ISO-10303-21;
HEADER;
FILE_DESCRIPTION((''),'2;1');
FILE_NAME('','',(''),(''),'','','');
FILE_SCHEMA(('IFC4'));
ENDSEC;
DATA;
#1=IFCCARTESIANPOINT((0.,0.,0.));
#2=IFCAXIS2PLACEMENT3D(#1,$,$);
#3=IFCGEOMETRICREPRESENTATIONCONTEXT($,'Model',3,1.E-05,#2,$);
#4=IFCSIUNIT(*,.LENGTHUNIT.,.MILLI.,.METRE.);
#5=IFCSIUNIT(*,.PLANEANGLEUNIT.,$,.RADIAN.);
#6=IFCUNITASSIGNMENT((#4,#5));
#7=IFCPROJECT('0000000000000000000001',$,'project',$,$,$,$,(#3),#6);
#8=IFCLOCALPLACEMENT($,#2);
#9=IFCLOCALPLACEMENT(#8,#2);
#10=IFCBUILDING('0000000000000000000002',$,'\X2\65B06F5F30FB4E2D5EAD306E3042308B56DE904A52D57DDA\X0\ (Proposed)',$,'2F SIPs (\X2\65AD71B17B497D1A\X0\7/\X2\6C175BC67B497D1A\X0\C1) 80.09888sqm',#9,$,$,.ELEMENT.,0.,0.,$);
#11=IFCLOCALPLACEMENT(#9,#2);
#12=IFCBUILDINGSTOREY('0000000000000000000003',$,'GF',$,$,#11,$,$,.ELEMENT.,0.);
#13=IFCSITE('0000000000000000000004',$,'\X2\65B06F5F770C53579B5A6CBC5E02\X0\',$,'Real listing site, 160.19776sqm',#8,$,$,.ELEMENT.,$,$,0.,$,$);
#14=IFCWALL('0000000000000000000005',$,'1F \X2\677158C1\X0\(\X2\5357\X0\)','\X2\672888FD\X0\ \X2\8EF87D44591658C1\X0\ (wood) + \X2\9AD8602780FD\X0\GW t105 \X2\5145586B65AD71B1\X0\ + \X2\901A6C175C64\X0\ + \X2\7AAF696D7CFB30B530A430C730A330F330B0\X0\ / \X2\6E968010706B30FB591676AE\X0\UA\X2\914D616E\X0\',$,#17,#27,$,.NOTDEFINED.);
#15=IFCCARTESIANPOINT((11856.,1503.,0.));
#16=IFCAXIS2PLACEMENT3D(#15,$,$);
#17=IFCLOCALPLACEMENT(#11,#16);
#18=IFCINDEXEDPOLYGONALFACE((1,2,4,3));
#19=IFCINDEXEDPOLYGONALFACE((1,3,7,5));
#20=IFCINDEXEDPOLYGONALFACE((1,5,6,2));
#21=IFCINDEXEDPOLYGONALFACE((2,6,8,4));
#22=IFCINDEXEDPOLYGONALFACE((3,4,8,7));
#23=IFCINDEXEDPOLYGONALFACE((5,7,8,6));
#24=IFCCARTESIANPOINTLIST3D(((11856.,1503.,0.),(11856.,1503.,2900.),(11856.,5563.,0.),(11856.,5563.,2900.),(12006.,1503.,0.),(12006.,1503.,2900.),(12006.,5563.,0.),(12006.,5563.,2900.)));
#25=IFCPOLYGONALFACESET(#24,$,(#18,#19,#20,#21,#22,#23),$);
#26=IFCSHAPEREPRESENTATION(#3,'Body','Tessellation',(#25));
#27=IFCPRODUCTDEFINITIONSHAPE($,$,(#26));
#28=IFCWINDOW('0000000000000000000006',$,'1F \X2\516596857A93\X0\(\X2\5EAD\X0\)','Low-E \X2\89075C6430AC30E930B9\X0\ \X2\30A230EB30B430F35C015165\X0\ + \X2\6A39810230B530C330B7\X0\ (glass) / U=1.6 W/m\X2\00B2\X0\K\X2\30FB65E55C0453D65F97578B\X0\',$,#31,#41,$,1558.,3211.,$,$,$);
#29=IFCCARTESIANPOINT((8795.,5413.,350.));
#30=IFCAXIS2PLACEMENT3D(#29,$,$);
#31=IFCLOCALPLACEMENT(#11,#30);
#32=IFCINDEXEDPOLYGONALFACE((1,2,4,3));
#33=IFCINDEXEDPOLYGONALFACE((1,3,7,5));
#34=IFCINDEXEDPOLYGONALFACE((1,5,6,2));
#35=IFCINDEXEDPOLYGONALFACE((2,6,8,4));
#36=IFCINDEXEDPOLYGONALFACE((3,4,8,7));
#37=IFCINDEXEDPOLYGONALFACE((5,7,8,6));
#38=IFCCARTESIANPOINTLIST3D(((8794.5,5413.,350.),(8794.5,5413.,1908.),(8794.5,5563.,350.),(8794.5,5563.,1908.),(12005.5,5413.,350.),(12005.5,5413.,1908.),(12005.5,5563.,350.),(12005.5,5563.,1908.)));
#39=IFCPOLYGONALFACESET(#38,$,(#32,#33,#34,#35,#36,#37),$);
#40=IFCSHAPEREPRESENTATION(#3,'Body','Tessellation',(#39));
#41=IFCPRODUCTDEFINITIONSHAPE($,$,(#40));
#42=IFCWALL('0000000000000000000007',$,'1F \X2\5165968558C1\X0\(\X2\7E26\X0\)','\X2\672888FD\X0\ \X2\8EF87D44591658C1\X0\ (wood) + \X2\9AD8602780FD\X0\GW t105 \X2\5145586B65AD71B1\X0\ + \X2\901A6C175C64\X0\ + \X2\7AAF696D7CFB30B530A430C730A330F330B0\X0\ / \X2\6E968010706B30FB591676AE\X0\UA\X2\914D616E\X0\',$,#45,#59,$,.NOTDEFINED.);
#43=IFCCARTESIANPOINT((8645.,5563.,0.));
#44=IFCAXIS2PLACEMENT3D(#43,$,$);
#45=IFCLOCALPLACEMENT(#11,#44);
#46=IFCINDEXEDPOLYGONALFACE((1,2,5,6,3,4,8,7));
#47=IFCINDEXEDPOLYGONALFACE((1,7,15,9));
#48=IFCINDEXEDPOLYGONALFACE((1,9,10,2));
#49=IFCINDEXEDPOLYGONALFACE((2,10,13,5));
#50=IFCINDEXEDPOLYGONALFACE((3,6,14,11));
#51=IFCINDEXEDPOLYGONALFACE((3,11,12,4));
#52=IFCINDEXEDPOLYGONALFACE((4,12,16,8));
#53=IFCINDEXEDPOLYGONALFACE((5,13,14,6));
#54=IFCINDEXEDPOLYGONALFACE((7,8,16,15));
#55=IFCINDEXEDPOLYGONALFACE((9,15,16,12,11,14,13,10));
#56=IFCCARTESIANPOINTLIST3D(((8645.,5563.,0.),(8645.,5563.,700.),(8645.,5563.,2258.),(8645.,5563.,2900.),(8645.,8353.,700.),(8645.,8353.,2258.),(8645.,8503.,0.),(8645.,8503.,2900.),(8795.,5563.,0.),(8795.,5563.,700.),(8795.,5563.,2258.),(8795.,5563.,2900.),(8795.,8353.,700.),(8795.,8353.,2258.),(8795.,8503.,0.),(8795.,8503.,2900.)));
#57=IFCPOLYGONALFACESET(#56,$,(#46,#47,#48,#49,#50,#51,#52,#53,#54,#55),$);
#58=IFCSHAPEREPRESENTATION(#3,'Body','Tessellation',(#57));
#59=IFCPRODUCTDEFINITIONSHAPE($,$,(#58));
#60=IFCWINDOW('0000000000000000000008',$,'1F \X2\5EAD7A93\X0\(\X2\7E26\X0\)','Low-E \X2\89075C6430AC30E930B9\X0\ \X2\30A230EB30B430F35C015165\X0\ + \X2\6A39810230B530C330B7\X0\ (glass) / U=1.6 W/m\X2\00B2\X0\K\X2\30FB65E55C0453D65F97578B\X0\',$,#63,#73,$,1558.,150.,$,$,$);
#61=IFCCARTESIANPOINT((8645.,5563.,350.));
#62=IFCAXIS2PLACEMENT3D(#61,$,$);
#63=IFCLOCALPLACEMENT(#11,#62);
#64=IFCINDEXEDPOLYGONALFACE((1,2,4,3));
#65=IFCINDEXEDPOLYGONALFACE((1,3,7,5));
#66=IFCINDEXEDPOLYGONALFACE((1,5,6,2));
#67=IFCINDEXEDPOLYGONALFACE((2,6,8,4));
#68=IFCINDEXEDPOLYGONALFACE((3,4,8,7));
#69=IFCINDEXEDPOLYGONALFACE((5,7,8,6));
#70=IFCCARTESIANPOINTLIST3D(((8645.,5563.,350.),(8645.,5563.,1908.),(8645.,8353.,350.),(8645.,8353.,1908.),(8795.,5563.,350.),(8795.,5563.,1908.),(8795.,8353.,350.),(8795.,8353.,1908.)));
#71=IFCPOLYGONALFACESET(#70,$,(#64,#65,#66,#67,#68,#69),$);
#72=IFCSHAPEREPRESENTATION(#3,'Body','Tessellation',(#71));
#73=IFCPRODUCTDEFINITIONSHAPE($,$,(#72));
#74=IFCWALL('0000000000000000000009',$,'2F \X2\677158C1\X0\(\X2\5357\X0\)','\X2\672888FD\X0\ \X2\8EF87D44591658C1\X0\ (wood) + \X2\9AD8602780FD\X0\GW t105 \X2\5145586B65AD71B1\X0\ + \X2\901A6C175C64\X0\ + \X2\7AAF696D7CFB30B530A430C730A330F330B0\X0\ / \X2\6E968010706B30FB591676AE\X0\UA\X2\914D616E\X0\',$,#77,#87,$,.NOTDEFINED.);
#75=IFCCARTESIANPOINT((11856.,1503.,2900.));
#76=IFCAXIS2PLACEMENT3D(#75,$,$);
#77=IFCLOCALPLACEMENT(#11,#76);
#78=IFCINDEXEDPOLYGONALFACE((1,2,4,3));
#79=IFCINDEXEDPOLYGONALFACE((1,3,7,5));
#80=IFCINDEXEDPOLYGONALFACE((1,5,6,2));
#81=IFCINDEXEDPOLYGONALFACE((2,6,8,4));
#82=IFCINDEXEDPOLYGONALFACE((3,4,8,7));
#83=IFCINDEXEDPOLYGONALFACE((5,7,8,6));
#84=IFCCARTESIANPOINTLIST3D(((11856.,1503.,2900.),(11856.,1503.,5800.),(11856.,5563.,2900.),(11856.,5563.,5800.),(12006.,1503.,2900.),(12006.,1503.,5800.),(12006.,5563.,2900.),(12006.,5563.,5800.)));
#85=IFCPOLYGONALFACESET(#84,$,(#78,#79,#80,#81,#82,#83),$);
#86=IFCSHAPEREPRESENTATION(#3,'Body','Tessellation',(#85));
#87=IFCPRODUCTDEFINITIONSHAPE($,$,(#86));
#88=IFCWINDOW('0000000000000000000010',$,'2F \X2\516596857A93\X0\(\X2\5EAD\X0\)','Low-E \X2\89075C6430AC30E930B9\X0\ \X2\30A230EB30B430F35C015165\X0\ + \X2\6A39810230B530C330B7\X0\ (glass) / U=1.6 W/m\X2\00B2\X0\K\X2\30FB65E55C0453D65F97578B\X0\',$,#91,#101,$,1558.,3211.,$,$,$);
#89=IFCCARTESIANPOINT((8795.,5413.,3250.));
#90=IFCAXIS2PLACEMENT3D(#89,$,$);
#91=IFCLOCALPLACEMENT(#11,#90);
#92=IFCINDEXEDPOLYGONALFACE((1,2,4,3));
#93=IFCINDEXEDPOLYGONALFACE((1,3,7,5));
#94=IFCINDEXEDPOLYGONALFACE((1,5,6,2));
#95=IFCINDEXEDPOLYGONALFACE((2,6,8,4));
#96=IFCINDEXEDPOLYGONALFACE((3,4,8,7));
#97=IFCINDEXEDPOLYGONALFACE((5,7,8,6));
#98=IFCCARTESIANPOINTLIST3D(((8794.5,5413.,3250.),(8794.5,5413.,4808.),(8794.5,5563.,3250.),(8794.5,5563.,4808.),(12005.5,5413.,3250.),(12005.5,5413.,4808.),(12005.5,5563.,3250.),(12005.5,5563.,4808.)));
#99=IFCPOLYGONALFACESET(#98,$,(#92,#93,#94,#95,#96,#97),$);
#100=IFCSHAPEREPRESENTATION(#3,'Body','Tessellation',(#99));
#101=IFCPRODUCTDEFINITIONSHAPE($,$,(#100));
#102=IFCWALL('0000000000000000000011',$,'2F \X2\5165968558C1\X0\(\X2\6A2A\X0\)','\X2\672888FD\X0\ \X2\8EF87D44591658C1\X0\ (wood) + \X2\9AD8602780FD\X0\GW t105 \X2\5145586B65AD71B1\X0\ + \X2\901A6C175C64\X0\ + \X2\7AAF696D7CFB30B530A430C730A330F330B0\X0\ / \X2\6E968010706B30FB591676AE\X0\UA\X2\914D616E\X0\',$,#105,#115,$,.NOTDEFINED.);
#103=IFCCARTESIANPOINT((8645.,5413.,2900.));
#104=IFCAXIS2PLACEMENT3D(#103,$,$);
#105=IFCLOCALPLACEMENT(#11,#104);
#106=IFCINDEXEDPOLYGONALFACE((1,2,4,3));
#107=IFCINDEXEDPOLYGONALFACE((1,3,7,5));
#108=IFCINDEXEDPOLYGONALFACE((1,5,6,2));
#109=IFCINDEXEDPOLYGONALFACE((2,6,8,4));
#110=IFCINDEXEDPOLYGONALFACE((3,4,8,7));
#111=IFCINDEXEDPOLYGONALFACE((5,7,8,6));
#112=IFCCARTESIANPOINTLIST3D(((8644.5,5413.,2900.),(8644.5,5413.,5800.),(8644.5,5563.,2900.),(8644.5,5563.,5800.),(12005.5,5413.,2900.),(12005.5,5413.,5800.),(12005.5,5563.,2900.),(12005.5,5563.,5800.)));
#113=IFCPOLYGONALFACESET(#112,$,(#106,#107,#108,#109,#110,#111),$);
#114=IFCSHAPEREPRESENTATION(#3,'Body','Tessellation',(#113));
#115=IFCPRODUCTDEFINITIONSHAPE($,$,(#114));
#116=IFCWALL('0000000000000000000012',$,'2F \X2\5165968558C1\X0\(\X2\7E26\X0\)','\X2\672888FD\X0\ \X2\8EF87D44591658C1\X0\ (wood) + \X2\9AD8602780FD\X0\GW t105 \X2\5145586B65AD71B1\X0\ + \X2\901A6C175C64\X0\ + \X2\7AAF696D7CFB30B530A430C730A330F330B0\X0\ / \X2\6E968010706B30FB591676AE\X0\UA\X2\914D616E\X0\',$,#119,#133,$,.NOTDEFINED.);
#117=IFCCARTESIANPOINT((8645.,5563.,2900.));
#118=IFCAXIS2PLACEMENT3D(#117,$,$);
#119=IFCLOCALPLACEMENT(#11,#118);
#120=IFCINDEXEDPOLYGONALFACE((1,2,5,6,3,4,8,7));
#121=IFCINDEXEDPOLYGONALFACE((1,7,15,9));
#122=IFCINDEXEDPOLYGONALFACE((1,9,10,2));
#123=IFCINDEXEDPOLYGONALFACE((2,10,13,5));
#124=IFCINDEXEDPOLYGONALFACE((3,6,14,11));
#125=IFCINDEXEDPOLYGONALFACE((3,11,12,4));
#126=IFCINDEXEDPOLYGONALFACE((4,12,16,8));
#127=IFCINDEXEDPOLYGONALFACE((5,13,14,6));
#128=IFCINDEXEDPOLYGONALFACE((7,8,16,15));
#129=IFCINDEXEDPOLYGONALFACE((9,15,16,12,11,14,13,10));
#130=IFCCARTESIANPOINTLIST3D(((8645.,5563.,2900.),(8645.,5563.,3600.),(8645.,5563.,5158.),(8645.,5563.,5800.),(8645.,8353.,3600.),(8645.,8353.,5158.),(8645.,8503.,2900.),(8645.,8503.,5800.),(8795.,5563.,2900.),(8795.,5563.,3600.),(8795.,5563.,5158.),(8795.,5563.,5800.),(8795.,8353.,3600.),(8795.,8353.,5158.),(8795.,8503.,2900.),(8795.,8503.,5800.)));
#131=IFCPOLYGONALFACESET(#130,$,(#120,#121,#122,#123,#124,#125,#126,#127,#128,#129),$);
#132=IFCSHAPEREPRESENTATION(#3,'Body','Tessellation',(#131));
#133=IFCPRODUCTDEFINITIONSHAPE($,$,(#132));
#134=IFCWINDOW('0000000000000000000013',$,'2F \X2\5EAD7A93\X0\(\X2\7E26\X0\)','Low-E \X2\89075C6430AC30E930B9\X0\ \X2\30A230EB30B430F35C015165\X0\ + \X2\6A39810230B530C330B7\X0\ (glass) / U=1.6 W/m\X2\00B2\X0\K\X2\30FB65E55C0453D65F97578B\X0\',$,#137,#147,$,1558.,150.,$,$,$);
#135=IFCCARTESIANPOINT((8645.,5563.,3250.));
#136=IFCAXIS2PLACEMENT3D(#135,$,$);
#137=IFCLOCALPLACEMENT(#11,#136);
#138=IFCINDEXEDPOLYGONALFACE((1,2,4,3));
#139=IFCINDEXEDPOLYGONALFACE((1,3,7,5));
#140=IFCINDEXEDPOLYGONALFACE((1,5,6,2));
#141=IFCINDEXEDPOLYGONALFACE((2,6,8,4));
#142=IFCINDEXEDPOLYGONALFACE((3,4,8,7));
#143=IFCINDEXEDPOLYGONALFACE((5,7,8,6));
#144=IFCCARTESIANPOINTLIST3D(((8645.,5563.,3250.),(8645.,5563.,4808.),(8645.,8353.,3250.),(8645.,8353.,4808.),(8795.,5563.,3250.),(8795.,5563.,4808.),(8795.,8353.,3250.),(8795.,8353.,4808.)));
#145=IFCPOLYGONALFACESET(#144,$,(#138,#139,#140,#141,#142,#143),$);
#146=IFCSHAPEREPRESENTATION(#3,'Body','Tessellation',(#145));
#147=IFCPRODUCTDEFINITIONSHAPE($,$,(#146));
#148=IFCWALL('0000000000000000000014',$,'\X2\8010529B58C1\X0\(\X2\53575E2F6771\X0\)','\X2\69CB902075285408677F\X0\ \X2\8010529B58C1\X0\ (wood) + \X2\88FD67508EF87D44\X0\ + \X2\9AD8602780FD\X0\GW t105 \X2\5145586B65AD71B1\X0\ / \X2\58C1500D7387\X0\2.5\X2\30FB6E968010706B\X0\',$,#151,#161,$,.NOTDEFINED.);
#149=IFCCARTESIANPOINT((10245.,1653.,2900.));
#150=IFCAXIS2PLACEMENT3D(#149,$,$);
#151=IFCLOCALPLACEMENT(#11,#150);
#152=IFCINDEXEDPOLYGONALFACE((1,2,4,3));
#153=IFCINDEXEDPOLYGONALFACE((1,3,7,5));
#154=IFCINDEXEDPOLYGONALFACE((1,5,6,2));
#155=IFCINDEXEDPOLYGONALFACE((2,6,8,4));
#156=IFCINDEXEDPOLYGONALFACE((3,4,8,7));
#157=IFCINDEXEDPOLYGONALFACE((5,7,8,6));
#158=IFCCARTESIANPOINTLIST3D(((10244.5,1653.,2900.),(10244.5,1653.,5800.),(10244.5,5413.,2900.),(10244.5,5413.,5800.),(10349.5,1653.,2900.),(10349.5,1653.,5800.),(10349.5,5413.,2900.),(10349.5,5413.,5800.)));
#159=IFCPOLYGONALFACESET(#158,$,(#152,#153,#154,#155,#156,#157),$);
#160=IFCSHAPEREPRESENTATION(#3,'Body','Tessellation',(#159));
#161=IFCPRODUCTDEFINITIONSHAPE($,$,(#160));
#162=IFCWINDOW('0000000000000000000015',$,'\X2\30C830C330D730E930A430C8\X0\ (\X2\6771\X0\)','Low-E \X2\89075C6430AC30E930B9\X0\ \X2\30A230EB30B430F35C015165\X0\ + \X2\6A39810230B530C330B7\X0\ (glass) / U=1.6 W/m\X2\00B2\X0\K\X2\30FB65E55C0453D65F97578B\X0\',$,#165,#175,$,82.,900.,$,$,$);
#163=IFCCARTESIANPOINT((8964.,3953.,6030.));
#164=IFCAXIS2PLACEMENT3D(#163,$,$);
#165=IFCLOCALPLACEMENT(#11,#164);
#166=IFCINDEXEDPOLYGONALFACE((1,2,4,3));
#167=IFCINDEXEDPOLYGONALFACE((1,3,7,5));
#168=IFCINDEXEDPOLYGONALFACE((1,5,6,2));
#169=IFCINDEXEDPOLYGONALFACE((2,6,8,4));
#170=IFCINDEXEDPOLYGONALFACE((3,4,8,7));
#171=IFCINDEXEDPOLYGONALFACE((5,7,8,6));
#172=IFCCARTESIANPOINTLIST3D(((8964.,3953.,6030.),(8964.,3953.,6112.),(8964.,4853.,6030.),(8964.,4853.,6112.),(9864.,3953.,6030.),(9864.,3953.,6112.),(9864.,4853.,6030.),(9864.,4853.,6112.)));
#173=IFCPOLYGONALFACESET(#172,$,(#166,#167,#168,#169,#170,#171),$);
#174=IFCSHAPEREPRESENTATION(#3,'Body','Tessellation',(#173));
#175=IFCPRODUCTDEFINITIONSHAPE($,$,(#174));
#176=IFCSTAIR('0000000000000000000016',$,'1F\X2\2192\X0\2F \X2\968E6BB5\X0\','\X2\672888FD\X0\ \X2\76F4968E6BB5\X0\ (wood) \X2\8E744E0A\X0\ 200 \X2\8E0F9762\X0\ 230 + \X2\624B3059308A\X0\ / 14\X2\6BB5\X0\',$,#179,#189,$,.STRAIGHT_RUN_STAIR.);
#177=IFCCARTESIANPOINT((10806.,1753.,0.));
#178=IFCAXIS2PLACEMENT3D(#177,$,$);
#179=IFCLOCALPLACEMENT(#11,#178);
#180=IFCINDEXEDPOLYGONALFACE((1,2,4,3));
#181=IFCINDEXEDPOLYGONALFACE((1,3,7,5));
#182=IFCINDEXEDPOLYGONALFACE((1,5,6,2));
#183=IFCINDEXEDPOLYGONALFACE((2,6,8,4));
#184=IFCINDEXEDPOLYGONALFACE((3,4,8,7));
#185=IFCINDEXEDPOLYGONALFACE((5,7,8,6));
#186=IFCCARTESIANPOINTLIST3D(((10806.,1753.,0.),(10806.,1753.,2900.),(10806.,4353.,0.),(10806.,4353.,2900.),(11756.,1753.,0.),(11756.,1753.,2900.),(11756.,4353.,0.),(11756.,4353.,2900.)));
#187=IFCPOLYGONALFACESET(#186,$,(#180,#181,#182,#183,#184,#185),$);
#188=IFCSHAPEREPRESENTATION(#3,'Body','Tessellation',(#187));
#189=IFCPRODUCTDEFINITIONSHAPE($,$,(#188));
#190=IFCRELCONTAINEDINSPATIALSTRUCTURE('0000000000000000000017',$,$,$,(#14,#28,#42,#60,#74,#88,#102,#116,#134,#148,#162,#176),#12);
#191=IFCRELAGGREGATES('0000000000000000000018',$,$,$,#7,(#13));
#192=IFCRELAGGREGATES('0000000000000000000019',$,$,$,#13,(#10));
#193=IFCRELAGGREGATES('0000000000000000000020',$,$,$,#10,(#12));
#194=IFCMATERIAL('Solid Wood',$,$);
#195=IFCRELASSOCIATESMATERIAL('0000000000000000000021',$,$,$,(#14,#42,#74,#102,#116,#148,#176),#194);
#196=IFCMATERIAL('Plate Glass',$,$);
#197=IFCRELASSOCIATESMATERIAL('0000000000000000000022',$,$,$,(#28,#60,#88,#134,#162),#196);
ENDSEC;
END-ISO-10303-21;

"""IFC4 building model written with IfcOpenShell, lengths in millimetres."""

from ifc_helpers import new_model, si_unit, frame, frame_2d, origin, place, context, project, spatial, rectangle, extrude, material, element, fill, save


model = new_model("IFC4")

# Units and contexts
model_context = context("Model", 3, precision=1e-05, world=origin())
ifc_project = project(units=[si_unit("LENGTHUNIT", "METRE", prefix="MILLI"), si_unit("PLANEANGLEUNIT", "RADIAN")], contexts=[model_context])

# Site, building, storey
site_placement = place(None, origin())
site = spatial("IfcSite", under=ifc_project, at=site_placement, Name="新潟県南魚沼市", ObjectType="Real listing site, 160.19776sqm", CompositionType="ELEMENT", RefElevation=0.0)
building_placement = place(site_placement, origin())
building = spatial("IfcBuilding", under=site, at=building_placement, Name="新潟・中庭のある回遊動線 (Proposed)", ObjectType="2F SIPs (断熱等級7/気密等級C1) 80.09888sqm", CompositionType="ELEMENT", ElevationOfRefHeight=0.0, ElevationOfTerrain=0.0)
storey_placement = place(building_placement, origin())
storey = spatial("IfcBuildingStorey", under=building, at=storey_placement, Name="GF", CompositionType="ELEMENT", Elevation=0.0)

# Shared definitions
ifc_material_1 = material(Name="Solid Wood")

# Wall, opening, window
wall_1_placement = place(storey_placement, frame((11856.0, 1503.0, 0.0)))
wall_1 = element("IfcWall", 1, at=wall_1_placement, inside=storey, material=ifc_material_1, Name="1F 東壁(南)", Description="木製 軸組外壁 (wood) + 高性能GW t105 充填断熱 + 通気層 + 窯業系サイディング / 準耐火・外皮UA配慮", PredefinedType="NOTDEFINED", context=model_context, shape_type="SweptSolid", body=[
    extrude(rectangle(XDim=150.0, YDim=4060.0, at=frame_2d((75.0, 2030.0))), frame((11856.0, 1503.0, 0.0)), (0.0, 0.0, 1.0), 2900.0),
])
opening_1_placement = place(storey_placement, frame((8795.0, 5413.0, 350.0)))
opening_1 = element("IfcOpeningElement", 2, at=opening_1_placement, cuts=wall_1, PredefinedType="NOTDEFINED", context=model_context, shape_type="SweptSolid", body=[
    extrude(rectangle(XDim=3211.0, YDim=150.0, at=frame_2d((1605.0, 75.0))), frame((8795.0, 5413.0, 350.0)), (0.0, 0.0, 1.0), 1558.0),
])
ifc_material_2 = material(Name="Plate Glass")
window_1_placement = place(storey_placement, frame((8795.0, 5413.0, 350.0)))
window_1 = element("IfcWindow", 3, at=window_1_placement, inside=storey, material=ifc_material_2, Name="1F 入隅窓(庭)", Description="Low-E 複層ガラス アルゴン封入 + 樹脂サッシ (glass) / U=1.6 W/m²K・日射取得型", OverallHeight=1558.0, OverallWidth=3211.0, context=model_context, shape_type="SweptSolid", body=[
    extrude(rectangle(XDim=3211.0, YDim=150.0, at=frame_2d((1605.0, 75.0))), frame((8795.0, 5413.0, 350.0)), (0.0, 0.0, 1.0), 1558.0),
])
fill(opening_1, window_1)

# Wall, opening, window
wall_2_placement = place(storey_placement, frame((8645.0, 5563.0, 0.0)))
wall_2 = element("IfcWall", 4, at=wall_2_placement, inside=storey, material=ifc_material_1, Name="1F 入隅壁(縦)", Description="木製 軸組外壁 (wood) + 高性能GW t105 充填断熱 + 通気層 + 窯業系サイディング / 準耐火・外皮UA配慮", PredefinedType="NOTDEFINED", context=model_context, shape_type="SweptSolid", body=[
    extrude(rectangle(XDim=150.0, YDim=2940.0, at=frame_2d((75.0, 1470.0))), frame((8645.0, 5563.0, 0.0)), (0.0, 0.0, 1.0), 2900.0),
])
opening_2_placement = place(storey_placement, frame((8645.0, 5563.0, 350.0)))
opening_2 = element("IfcOpeningElement", 5, at=opening_2_placement, cuts=wall_2, PredefinedType="NOTDEFINED", context=model_context, shape_type="SweptSolid", body=[
    extrude(rectangle(XDim=150.0, YDim=2790.0, at=frame_2d((75.0, 1395.0))), frame((8645.0, 5563.0, 350.0)), (0.0, 0.0, 1.0), 1558.0),
])
window_2_placement = place(storey_placement, frame((8645.0, 5563.0, 350.0)))
window_2 = element("IfcWindow", 6, at=window_2_placement, inside=storey, material=ifc_material_2, Name="1F 庭窓(縦)", Description="Low-E 複層ガラス アルゴン封入 + 樹脂サッシ (glass) / U=1.6 W/m²K・日射取得型", OverallHeight=1558.0, OverallWidth=150.0, context=model_context, shape_type="SweptSolid", body=[
    extrude(rectangle(XDim=150.0, YDim=2790.0, at=frame_2d((75.0, 1395.0))), frame((8645.0, 5563.0, 350.0)), (0.0, 0.0, 1.0), 1558.0),
])
fill(opening_2, window_2)

# Wall, opening, window
wall_3_placement = place(storey_placement, frame((11856.0, 1503.0, 2900.0)))
wall_3 = element("IfcWall", 7, at=wall_3_placement, inside=storey, material=ifc_material_1, Name="2F 東壁(南)", Description="木製 軸組外壁 (wood) + 高性能GW t105 充填断熱 + 通気層 + 窯業系サイディング / 準耐火・外皮UA配慮", PredefinedType="NOTDEFINED", context=model_context, shape_type="SweptSolid", body=[
    extrude(rectangle(XDim=150.0, YDim=4060.0, at=frame_2d((75.0, 2030.0))), frame((11856.0, 1503.0, 2900.0)), (0.0, 0.0, 1.0), 2900.0),
])
opening_3_placement = place(storey_placement, frame((8795.0, 5413.0, 3250.0)))
opening_3 = element("IfcOpeningElement", 8, at=opening_3_placement, cuts=wall_3, PredefinedType="NOTDEFINED", context=model_context, shape_type="SweptSolid", body=[
    extrude(rectangle(XDim=3211.0, YDim=150.0, at=frame_2d((1605.0, 75.0))), frame((8795.0, 5413.0, 3250.0)), (0.0, 0.0, 1.0), 1558.0),
])
window_3_placement = place(storey_placement, frame((8795.0, 5413.0, 3250.0)))
window_3 = element("IfcWindow", 9, at=window_3_placement, inside=storey, material=ifc_material_2, Name="2F 入隅窓(庭)", Description="Low-E 複層ガラス アルゴン封入 + 樹脂サッシ (glass) / U=1.6 W/m²K・日射取得型", OverallHeight=1558.0, OverallWidth=3211.0, context=model_context, shape_type="SweptSolid", body=[
    extrude(rectangle(XDim=3211.0, YDim=150.0, at=frame_2d((1605.0, 75.0))), frame((8795.0, 5413.0, 3250.0)), (0.0, 0.0, 1.0), 1558.0),
])
fill(opening_3, window_3)

# Wall
wall_4_placement = place(storey_placement, frame((8645.0, 5413.0, 2900.0)))
element("IfcWall", 10, at=wall_4_placement, inside=storey, material=ifc_material_1, Name="2F 入隅壁(横)", Description="木製 軸組外壁 (wood) + 高性能GW t105 充填断熱 + 通気層 + 窯業系サイディング / 準耐火・外皮UA配慮", PredefinedType="NOTDEFINED", context=model_context, shape_type="SweptSolid", body=[
    extrude(rectangle(XDim=3361.0, YDim=150.0, at=frame_2d((1680.0, 75.0))), frame((8645.0, 5413.0, 2900.0)), (0.0, 0.0, 1.0), 2900.0),
])

# Wall, opening, window
wall_5_placement = place(storey_placement, frame((8645.0, 5563.0, 2900.0)))
wall_5 = element("IfcWall", 11, at=wall_5_placement, inside=storey, material=ifc_material_1, Name="2F 入隅壁(縦)", Description="木製 軸組外壁 (wood) + 高性能GW t105 充填断熱 + 通気層 + 窯業系サイディング / 準耐火・外皮UA配慮", PredefinedType="NOTDEFINED", context=model_context, shape_type="SweptSolid", body=[
    extrude(rectangle(XDim=150.0, YDim=2940.0, at=frame_2d((75.0, 1470.0))), frame((8645.0, 5563.0, 2900.0)), (0.0, 0.0, 1.0), 2900.0),
])
opening_4_placement = place(storey_placement, frame((8645.0, 5563.0, 3250.0)))
opening_4 = element("IfcOpeningElement", 12, at=opening_4_placement, cuts=wall_5, PredefinedType="NOTDEFINED", context=model_context, shape_type="SweptSolid", body=[
    extrude(rectangle(XDim=150.0, YDim=2790.0, at=frame_2d((75.0, 1395.0))), frame((8645.0, 5563.0, 3250.0)), (0.0, 0.0, 1.0), 1558.0),
])
window_4_placement = place(storey_placement, frame((8645.0, 5563.0, 3250.0)))
window_4 = element("IfcWindow", 13, at=window_4_placement, inside=storey, material=ifc_material_2, Name="2F 庭窓(縦)", Description="Low-E 複層ガラス アルゴン封入 + 樹脂サッシ (glass) / U=1.6 W/m²K・日射取得型", OverallHeight=1558.0, OverallWidth=150.0, context=model_context, shape_type="SweptSolid", body=[
    extrude(rectangle(XDim=150.0, YDim=2790.0, at=frame_2d((75.0, 1395.0))), frame((8645.0, 5563.0, 3250.0)), (0.0, 0.0, 1.0), 1558.0),
])
fill(opening_4, window_4)

# Wall
wall_6_placement = place(storey_placement, frame((10245.0, 1653.0, 2900.0)))
element("IfcWall", 14, at=wall_6_placement, inside=storey, material=ifc_material_1, Name="耐力壁(南帯東)", Description="構造用合板 耐力壁 (wood) + 製材軸組 + 高性能GW t105 充填断熱 / 壁倍率2.5・準耐火", PredefinedType="NOTDEFINED", context=model_context, shape_type="SweptSolid", body=[
    extrude(rectangle(XDim=105.0, YDim=3760.0, at=frame_2d((52.0, 1880.0))), frame((10245.0, 1653.0, 2900.0)), (0.0, 0.0, 1.0), 2900.0),
])

# Window
window_5_placement = place(storey_placement, frame((8964.0, 3953.0, 6030.0)))
element("IfcWindow", 15, at=window_5_placement, inside=storey, material=ifc_material_2, Name="トップライト (東)", Description="Low-E 複層ガラス アルゴン封入 + 樹脂サッシ (glass) / U=1.6 W/m²K・日射取得型", OverallHeight=82.0, OverallWidth=900.0, context=model_context, shape_type="SweptSolid", body=[
    extrude(rectangle(XDim=900.0, YDim=900.0, at=frame_2d((450.0, 450.0))), frame((8964.0, 3953.0, 6030.0)), (0.0, 0.0, 1.0), 82.0),
])

# Stair
stair_placement = place(storey_placement, frame((10806.0, 1753.0, 0.0)))
element("IfcStair", 16, at=stair_placement, inside=storey, material=ifc_material_1, Name="1F→2F 階段", Description="木製 直階段 (wood) 蹴上 200 踏面 230 + 手すり / 14段", PredefinedType="STRAIGHT_RUN_STAIR", context=model_context, shape_type="SweptSolid", body=[
    extrude(rectangle(XDim=950.0, YDim=2600.0, at=frame_2d((475.0, 1300.0))), frame((10806.0, 1753.0, 0.0)), (0.0, 0.0, 1.0), 2900.0),
])

save(model, "model.ifc")
